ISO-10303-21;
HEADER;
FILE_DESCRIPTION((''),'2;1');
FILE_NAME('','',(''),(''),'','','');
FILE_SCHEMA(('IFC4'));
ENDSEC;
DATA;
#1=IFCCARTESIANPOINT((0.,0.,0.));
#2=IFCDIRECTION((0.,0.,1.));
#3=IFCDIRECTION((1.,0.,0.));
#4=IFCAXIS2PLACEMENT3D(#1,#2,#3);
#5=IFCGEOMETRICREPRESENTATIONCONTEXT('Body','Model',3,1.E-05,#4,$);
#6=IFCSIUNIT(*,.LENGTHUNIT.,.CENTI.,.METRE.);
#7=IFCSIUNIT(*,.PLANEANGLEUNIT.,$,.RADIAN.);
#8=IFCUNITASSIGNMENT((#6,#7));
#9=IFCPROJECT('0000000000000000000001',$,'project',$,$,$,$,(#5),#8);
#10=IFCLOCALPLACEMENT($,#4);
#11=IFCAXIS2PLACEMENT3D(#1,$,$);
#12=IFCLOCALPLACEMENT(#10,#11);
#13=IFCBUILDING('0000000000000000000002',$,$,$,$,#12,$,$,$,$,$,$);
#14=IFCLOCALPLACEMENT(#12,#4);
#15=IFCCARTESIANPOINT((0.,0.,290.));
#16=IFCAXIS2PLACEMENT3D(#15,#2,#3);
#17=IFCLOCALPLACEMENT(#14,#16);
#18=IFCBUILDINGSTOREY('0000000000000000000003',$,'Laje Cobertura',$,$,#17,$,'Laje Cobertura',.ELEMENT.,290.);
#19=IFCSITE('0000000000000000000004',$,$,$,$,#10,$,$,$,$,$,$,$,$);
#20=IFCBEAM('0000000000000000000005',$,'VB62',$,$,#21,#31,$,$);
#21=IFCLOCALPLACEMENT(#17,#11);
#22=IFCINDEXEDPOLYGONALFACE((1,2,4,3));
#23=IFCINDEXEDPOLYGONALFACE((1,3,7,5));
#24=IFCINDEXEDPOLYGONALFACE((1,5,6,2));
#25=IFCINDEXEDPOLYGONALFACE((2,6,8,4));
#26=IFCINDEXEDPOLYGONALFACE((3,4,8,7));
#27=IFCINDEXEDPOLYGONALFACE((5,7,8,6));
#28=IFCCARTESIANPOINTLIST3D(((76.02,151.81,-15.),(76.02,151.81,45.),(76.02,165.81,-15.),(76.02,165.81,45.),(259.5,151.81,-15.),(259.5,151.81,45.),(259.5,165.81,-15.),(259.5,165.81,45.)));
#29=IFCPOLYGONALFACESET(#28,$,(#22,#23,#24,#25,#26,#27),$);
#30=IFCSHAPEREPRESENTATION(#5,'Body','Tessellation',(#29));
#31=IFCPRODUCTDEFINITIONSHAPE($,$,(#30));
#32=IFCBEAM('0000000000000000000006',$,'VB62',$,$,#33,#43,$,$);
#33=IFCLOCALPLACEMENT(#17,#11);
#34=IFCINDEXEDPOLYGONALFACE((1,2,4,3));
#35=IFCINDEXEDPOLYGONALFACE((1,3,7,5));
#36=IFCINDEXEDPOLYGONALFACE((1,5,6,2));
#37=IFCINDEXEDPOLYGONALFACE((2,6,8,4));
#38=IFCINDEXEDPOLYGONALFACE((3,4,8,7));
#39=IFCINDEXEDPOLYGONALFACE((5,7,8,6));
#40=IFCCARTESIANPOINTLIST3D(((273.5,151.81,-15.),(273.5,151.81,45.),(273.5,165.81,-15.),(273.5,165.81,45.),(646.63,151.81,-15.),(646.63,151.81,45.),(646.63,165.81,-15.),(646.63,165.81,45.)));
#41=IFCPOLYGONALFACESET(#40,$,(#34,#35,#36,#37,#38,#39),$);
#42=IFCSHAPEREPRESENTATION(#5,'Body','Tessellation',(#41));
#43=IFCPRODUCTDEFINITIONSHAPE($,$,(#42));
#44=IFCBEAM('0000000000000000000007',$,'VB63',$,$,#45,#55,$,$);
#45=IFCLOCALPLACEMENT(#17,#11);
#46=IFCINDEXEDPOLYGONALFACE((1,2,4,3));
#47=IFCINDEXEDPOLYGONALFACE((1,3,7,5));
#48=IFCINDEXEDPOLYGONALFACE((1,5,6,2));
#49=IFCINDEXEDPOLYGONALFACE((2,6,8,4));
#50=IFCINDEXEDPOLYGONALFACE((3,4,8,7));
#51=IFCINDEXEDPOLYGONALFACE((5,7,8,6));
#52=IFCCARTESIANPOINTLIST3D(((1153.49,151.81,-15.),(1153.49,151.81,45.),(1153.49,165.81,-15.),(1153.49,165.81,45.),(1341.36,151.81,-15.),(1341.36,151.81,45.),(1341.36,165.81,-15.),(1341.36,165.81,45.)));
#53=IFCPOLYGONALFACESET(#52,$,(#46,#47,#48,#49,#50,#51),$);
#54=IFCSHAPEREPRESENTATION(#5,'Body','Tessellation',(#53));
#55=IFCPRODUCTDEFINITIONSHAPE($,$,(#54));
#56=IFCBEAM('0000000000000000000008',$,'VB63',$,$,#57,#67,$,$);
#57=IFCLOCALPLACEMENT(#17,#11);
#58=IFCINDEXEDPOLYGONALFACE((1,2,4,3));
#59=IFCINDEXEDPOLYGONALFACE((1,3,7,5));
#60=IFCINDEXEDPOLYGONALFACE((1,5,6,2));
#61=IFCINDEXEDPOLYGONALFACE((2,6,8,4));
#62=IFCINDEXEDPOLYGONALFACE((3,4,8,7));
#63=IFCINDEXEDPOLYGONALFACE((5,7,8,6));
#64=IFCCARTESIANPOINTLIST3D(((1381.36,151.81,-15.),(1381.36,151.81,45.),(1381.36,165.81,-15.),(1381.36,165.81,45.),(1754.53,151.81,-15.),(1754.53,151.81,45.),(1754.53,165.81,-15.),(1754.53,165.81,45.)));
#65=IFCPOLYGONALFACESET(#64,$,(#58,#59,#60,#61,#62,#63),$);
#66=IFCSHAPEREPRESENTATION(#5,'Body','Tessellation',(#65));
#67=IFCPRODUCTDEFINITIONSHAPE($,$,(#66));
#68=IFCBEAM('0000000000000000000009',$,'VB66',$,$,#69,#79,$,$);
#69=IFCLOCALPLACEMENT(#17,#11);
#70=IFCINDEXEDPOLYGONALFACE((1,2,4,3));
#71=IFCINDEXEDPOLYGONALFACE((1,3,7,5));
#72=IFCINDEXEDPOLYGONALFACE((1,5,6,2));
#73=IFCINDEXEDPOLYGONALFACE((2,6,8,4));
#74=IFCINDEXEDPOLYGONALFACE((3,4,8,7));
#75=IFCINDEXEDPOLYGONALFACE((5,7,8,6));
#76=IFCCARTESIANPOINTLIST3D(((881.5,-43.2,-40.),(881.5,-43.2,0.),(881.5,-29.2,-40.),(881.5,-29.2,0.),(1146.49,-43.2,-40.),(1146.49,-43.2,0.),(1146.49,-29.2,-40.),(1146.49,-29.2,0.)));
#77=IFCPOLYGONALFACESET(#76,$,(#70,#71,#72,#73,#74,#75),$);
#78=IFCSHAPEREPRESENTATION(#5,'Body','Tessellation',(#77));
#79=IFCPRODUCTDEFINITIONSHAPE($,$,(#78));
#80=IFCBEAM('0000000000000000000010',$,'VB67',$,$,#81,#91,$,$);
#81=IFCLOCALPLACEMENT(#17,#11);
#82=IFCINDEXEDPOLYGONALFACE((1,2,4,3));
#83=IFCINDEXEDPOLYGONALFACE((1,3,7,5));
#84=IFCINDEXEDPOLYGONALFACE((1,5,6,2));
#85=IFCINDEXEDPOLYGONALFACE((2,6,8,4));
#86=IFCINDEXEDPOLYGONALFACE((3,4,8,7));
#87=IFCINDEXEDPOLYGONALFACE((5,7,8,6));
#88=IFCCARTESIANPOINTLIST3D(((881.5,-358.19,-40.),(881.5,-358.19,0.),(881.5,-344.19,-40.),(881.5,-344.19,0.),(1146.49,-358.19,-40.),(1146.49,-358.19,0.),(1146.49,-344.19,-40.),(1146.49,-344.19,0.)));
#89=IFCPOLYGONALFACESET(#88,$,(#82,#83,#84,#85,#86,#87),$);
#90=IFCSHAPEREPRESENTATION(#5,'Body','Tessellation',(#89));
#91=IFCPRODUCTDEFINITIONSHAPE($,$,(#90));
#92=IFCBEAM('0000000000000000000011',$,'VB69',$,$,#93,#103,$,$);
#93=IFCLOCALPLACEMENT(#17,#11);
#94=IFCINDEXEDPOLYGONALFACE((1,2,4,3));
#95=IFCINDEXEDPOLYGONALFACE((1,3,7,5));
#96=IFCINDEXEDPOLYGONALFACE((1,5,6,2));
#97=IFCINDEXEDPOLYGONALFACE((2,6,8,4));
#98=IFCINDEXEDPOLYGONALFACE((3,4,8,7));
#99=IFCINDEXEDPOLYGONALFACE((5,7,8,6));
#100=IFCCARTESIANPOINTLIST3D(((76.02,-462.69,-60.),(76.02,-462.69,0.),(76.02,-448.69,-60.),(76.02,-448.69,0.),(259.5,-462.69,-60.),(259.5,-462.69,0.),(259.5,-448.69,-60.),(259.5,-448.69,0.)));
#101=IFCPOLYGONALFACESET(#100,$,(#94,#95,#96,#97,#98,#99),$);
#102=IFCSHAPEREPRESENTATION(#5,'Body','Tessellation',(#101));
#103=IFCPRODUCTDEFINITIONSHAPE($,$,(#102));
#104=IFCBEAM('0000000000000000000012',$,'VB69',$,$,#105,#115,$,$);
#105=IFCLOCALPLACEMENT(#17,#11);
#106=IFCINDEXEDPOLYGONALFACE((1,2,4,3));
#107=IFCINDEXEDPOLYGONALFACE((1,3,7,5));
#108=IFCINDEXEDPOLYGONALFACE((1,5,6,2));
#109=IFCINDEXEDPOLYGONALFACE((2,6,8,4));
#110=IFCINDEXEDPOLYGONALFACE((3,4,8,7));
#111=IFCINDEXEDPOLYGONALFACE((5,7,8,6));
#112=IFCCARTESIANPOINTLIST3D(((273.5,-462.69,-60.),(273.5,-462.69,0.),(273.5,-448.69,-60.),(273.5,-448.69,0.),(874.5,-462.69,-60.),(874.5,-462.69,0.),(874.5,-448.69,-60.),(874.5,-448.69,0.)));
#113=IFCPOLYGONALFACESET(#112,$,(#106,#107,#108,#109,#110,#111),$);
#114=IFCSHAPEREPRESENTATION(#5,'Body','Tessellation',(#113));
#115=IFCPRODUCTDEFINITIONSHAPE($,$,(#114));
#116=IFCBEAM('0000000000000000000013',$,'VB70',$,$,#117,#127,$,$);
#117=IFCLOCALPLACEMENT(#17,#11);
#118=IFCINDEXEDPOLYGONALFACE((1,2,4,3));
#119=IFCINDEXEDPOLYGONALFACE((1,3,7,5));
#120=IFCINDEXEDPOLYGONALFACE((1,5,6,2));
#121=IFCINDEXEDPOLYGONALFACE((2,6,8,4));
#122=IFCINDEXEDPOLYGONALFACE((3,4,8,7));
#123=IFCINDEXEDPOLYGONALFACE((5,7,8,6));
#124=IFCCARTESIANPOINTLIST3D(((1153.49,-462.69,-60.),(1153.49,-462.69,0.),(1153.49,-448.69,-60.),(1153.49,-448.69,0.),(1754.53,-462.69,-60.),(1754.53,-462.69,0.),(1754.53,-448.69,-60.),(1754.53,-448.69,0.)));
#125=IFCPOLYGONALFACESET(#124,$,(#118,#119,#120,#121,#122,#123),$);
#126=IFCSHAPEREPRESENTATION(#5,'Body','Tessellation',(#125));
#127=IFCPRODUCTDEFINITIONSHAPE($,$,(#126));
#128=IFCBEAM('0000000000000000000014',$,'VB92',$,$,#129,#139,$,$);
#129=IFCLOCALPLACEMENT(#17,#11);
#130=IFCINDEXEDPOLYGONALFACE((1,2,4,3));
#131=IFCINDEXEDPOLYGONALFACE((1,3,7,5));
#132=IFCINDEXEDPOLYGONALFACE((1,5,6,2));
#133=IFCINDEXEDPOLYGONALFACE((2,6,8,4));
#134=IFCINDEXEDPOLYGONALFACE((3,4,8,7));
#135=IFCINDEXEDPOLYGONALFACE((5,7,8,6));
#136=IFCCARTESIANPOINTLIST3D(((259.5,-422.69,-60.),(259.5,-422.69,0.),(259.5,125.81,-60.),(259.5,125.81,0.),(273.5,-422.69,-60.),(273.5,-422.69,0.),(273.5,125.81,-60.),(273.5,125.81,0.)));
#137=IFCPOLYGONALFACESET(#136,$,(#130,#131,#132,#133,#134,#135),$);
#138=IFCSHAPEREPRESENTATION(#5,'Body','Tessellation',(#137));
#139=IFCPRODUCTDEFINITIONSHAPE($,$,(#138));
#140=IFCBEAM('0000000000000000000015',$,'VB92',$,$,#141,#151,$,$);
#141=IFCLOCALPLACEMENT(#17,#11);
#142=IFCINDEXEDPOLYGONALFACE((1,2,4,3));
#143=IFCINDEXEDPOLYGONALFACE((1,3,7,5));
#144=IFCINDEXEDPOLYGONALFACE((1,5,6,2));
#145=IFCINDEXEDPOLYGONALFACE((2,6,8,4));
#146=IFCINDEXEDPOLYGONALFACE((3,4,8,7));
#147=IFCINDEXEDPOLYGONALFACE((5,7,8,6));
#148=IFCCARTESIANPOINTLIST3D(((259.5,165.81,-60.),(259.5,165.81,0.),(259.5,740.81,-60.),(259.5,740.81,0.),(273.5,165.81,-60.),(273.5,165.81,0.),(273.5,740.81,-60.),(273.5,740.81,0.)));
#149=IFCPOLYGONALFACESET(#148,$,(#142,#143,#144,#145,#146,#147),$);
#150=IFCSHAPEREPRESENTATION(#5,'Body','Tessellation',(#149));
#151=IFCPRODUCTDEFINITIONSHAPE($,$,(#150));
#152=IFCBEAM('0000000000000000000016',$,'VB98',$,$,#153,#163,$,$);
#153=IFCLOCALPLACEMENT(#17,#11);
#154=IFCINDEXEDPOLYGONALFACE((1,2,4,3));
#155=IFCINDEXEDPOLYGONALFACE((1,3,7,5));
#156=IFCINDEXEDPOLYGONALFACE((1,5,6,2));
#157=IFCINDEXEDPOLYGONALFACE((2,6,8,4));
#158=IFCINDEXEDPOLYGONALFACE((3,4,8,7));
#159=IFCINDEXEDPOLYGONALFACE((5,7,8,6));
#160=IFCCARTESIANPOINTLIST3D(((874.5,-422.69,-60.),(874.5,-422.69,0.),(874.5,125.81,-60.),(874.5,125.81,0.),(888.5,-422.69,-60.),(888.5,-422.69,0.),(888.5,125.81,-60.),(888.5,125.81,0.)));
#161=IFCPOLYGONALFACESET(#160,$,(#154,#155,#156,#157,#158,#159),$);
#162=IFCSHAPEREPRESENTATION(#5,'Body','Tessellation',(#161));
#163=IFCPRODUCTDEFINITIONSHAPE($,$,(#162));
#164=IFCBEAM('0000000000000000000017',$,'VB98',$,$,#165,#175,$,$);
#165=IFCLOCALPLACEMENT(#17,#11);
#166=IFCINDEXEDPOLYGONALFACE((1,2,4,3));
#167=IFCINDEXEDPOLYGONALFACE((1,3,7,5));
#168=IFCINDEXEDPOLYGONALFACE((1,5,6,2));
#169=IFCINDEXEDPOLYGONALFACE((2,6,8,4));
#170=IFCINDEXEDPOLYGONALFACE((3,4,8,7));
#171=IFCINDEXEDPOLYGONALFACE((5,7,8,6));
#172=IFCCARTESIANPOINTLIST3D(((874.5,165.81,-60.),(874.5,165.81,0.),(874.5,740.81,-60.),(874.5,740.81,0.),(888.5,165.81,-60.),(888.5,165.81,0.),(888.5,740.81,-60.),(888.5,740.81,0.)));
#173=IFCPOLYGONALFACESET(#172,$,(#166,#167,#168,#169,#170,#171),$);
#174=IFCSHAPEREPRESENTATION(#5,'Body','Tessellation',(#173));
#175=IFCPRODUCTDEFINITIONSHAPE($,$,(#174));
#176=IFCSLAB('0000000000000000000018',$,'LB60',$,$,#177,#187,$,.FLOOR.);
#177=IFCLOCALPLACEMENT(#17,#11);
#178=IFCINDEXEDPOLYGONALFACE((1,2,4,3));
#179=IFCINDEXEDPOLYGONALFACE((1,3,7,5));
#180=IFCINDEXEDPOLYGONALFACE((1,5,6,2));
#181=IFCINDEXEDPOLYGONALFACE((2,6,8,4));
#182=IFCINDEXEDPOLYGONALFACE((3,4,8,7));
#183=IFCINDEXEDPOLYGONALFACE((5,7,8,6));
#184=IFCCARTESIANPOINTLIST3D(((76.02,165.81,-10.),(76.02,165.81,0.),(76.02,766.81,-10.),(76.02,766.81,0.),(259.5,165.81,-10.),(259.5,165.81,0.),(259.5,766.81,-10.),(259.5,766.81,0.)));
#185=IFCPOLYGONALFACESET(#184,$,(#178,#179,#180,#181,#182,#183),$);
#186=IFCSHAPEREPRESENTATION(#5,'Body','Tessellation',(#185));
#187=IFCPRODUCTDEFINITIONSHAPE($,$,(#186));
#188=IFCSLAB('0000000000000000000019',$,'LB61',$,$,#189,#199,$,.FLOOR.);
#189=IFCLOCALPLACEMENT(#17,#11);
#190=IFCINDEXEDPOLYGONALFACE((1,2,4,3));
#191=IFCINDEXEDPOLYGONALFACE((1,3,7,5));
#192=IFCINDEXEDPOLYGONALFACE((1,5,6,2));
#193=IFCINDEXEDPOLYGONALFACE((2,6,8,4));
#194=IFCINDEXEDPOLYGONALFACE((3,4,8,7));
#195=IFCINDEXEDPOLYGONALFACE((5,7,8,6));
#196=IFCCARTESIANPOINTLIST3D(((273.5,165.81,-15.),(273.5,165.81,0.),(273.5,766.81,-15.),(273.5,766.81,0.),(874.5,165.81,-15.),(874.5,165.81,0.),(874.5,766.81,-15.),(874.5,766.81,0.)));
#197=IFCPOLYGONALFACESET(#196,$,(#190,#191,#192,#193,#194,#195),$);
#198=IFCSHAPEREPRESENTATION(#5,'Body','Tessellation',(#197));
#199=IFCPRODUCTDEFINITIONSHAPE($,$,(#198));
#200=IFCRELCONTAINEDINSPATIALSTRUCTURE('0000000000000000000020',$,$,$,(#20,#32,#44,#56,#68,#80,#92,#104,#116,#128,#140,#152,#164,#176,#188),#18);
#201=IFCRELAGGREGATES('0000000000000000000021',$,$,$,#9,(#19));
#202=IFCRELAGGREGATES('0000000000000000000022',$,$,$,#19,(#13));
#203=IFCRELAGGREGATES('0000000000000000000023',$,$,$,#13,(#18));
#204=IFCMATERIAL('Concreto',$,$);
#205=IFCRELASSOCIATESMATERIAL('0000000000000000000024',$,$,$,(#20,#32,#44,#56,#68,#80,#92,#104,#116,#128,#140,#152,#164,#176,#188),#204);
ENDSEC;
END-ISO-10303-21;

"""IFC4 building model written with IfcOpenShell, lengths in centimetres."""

from ifc_helpers import new_model, si_unit, frame, origin, origin_with_axes, origin_2d_with_axis, place, context, project, spatial, polyline, rectangle, outline, extrude, material, element, save


model = new_model("IFC4")

# Units and contexts
model_context = context("Model", 3, precision=1e-05, world=origin_with_axes(), identifier="Body")
ifc_project = project(units=[si_unit("LENGTHUNIT", "METRE", prefix="CENTI"), si_unit("PLANEANGLEUNIT", "RADIAN")], contexts=[model_context])

# Site, building, storey
site_placement = place(None, origin_with_axes())
site = spatial("IfcSite", under=ifc_project, at=site_placement)
building_placement = place(site_placement, origin())
building = spatial("IfcBuilding", under=site, at=building_placement)
placement = place(building_placement, origin_with_axes())
storey_placement = place(placement, frame((0.0, 0.0, 290.0), z_axis=(0.0, 0.0, 1.0), x_axis=(1.0, 0.0, 0.0)))
storey = spatial("IfcBuildingStorey", under=building, at=storey_placement, Name="Laje Cobertura", LongName="Laje Cobertura", CompositionType="ELEMENT", Elevation=290.0)

# Shared definitions
ifc_material = material(Name="Concreto")

# Beams
beam_1_placement = place(storey_placement, frame((167.76, 158.81, 45.0), z_axis=(0.0, 0.0, 1.0), x_axis=(1.0, 0.0, 0.0)))
element("IfcBeam", 1, at=beam_1_placement, inside=storey, material=ifc_material, Name="VB62", context=model_context, shape_type="SolidModel", body=[
    extrude(rectangle(XDim=14.0, YDim=60.0, at=origin_2d_with_axis()), frame((-91.74, 0.0, -30.0), z_axis=(1.0, 0.0, 0.0), x_axis=(0.0, 1.0, 0.0)), (0.0, 0.0, 1.0), 183.48),
])
beam_2_placement = place(storey_placement, frame((460.06, 158.81, 45.0), z_axis=(0.0, 0.0, 1.0), x_axis=(1.0, 0.0, 0.0)))
element("IfcBeam", 2, at=beam_2_placement, inside=storey, material=ifc_material, Name="VB62", context=model_context, shape_type="SolidModel", body=[
    extrude(rectangle(XDim=14.0, YDim=60.0, at=origin_2d_with_axis()), frame((-186.56, 0.0, -30.0), z_axis=(1.0, 0.0, 0.0), x_axis=(0.0, 1.0, 0.0)), (0.0, 0.0, 1.0), 373.13),
])
beam_3_placement = place(storey_placement, frame((1247.42, 158.81, 45.0), z_axis=(0.0, 0.0, 1.0), x_axis=(1.0, 0.0, 0.0)))
element("IfcBeam", 3, at=beam_3_placement, inside=storey, material=ifc_material, Name="VB63", context=model_context, shape_type="SolidModel", body=[
    extrude(rectangle(XDim=14.0, YDim=60.0, at=origin_2d_with_axis()), frame((-93.94, 0.0, -30.0), z_axis=(1.0, 0.0, 0.0), x_axis=(0.0, 1.0, 0.0)), (0.0, 0.0, 1.0), 187.87),
])
beam_4_placement = place(storey_placement, frame((1567.94, 158.81, 45.0), z_axis=(0.0, 0.0, 1.0), x_axis=(1.0, 0.0, 0.0)))
element("IfcBeam", 4, at=beam_4_placement, inside=storey, material=ifc_material, Name="VB63", context=model_context, shape_type="SolidModel", body=[
    extrude(rectangle(XDim=14.0, YDim=60.0, at=origin_2d_with_axis()), frame((-186.59, 0.0, -30.0), z_axis=(1.0, 0.0, 0.0), x_axis=(0.0, 1.0, 0.0)), (0.0, 0.0, 1.0), 373.17),
])
for number, where, z_axis, x_axis, name in (
    (5, (1014.0, -36.2, 0.0), (0.0, 0.0, 1.0), (1.0, 0.0, 0.0), "VB66"),
    (6, (1014.0, -351.19, 0.0), (0.0, 0.0, 1.0), (1.0, 0.0, 0.0), "VB67"),
):
    element("IfcBeam", number, at=place(storey_placement, frame(where, z_axis=z_axis, x_axis=x_axis)), inside=storey, material=ifc_material, Name=name, context=model_context, shape_type="SolidModel", body=[
        extrude(rectangle(XDim=14.0, YDim=40.0, at=origin_2d_with_axis()), frame((-132.5, 0.0, -20.0), z_axis=(1.0, 0.0, 0.0), x_axis=(0.0, 1.0, 0.0)), (0.0, 0.0, 1.0), 264.99),
    ])
beam_5_placement = place(storey_placement, frame((167.76, -455.69, 0.0), z_axis=(0.0, 0.0, 1.0), x_axis=(1.0, 0.0, 0.0)))
element("IfcBeam", 7, at=beam_5_placement, inside=storey, material=ifc_material, Name="VB69", context=model_context, shape_type="SolidModel", body=[
    extrude(rectangle(XDim=14.0, YDim=60.0, at=origin_2d_with_axis()), frame((-91.74, 0.0, -30.0), z_axis=(1.0, 0.0, 0.0), x_axis=(0.0, -1.0, 0.0)), (0.0, 0.0, 1.0), 183.48),
])
beam_6_placement = place(storey_placement, frame((574.0, -455.69, 0.0), z_axis=(0.0, 0.0, 1.0), x_axis=(1.0, 0.0, 0.0)))
element("IfcBeam", 8, at=beam_6_placement, inside=storey, material=ifc_material, Name="VB69", context=model_context, shape_type="SolidModel", body=[
    extrude(rectangle(XDim=14.0, YDim=60.0, at=origin_2d_with_axis()), frame((-300.5, 0.0, -30.0), z_axis=(1.0, 0.0, 0.0), x_axis=(0.0, -1.0, 0.0)), (0.0, 0.0, 1.0), 601.0),
])
beam_7_placement = place(storey_placement, frame((1454.01, -455.69, 0.0), z_axis=(0.0, 0.0, 1.0), x_axis=(1.0, 0.0, 0.0)))
element("IfcBeam", 9, at=beam_7_placement, inside=storey, material=ifc_material, Name="VB70", context=model_context, shape_type="SolidModel", body=[
    extrude(rectangle(XDim=14.0, YDim=60.0, at=origin_2d_with_axis()), frame((-300.52, 0.0, -30.0), z_axis=(1.0, 0.0, 0.0), x_axis=(0.0, 1.0, 0.0)), (0.0, 0.0, 1.0), 601.04),
])
beam_8_placement = place(storey_placement, frame((266.5, -148.44, 0.0), z_axis=(0.0, 0.0, 1.0), x_axis=(1.0, 0.0, 0.0)))
element("IfcBeam", 10, at=beam_8_placement, inside=storey, material=ifc_material, Name="VB92", context=model_context, shape_type="SolidModel", body=[
    extrude(rectangle(XDim=14.0, YDim=60.0, at=origin_2d_with_axis()), frame((0.0, -274.25, -30.0), z_axis=(0.0, 1.0, 0.0), x_axis=(1.0, 0.0, 0.0)), (0.0, 0.0, 1.0), 548.5),
])
beam_9_placement = place(storey_placement, frame((266.5, 453.31, 0.0), z_axis=(0.0, 0.0, 1.0), x_axis=(1.0, 0.0, 0.0)))
element("IfcBeam", 11, at=beam_9_placement, inside=storey, material=ifc_material, Name="VB92", context=model_context, shape_type="SolidModel", body=[
    extrude(rectangle(XDim=14.0, YDim=60.0, at=origin_2d_with_axis()), frame((0.0, -287.5, -30.0), z_axis=(0.0, 1.0, 0.0), x_axis=(1.0, 0.0, 0.0)), (0.0, 0.0, 1.0), 575.0),
])
beam_10_placement = place(storey_placement, frame((881.5, -148.44, 0.0), z_axis=(0.0, 0.0, 1.0), x_axis=(1.0, 0.0, 0.0)))
element("IfcBeam", 12, at=beam_10_placement, inside=storey, material=ifc_material, Name="VB98", context=model_context, shape_type="SolidModel", body=[
    extrude(rectangle(XDim=14.0, YDim=60.0, at=origin_2d_with_axis()), frame((0.0, -274.25, -30.0), z_axis=(0.0, 1.0, 0.0), x_axis=(1.0, 0.0, 0.0)), (0.0, 0.0, 1.0), 548.5),
])
beam_11_placement = place(storey_placement, frame((881.5, 453.31, 0.0), z_axis=(0.0, 0.0, 1.0), x_axis=(1.0, 0.0, 0.0)))
element("IfcBeam", 13, at=beam_11_placement, inside=storey, material=ifc_material, Name="VB98", context=model_context, shape_type="SolidModel", body=[
    extrude(rectangle(XDim=14.0, YDim=60.0, at=origin_2d_with_axis()), frame((0.0, -287.5, -30.0), z_axis=(0.0, 1.0, 0.0), x_axis=(1.0, 0.0, 0.0)), (0.0, 0.0, 1.0), 575.0),
])

# Slabs
slab_1_placement = place(storey_placement, frame((167.76, 466.31, 0.0), z_axis=(0.0, 0.0, 1.0), x_axis=(1.0, 0.0, 0.0)))
element("IfcSlab", 14, at=slab_1_placement, inside=storey, material=ifc_material, Name="LB60", PredefinedType="FLOOR", context=model_context, shape_type="SolidModel", body=[
    extrude(outline(polyline([(91.74, 300.5), (-91.74, 300.5), (-91.74, -300.5), (91.74, -300.5), (91.74, 300.5), (91.74, 300.5)])), frame((0.0, 0.0, -10.0), z_axis=(0.0, 0.0, 1.0), x_axis=(1.0, 0.0, 0.0)), (0.0, 0.0, 1.0), 10.0),
])
slab_2_placement = place(storey_placement, frame((574.0, 466.31, 0.0), z_axis=(0.0, 0.0, 1.0), x_axis=(1.0, 0.0, 0.0)))
element("IfcSlab", 15, at=slab_2_placement, inside=storey, material=ifc_material, Name="LB61", PredefinedType="FLOOR", context=model_context, shape_type="SolidModel", body=[
    extrude(outline(polyline([(300.5, 300.5), (-300.5, 300.5), (-300.5, -300.5), (300.5, -300.5), (300.5, 300.5), (300.5, 300.5)])), frame((0.0, 0.0, -15.0), z_axis=(0.0, 0.0, 1.0), x_axis=(1.0, 0.0, 0.0)), (0.0, 0.0, 1.0), 15.0),
])

save(model, "model.ifc")
